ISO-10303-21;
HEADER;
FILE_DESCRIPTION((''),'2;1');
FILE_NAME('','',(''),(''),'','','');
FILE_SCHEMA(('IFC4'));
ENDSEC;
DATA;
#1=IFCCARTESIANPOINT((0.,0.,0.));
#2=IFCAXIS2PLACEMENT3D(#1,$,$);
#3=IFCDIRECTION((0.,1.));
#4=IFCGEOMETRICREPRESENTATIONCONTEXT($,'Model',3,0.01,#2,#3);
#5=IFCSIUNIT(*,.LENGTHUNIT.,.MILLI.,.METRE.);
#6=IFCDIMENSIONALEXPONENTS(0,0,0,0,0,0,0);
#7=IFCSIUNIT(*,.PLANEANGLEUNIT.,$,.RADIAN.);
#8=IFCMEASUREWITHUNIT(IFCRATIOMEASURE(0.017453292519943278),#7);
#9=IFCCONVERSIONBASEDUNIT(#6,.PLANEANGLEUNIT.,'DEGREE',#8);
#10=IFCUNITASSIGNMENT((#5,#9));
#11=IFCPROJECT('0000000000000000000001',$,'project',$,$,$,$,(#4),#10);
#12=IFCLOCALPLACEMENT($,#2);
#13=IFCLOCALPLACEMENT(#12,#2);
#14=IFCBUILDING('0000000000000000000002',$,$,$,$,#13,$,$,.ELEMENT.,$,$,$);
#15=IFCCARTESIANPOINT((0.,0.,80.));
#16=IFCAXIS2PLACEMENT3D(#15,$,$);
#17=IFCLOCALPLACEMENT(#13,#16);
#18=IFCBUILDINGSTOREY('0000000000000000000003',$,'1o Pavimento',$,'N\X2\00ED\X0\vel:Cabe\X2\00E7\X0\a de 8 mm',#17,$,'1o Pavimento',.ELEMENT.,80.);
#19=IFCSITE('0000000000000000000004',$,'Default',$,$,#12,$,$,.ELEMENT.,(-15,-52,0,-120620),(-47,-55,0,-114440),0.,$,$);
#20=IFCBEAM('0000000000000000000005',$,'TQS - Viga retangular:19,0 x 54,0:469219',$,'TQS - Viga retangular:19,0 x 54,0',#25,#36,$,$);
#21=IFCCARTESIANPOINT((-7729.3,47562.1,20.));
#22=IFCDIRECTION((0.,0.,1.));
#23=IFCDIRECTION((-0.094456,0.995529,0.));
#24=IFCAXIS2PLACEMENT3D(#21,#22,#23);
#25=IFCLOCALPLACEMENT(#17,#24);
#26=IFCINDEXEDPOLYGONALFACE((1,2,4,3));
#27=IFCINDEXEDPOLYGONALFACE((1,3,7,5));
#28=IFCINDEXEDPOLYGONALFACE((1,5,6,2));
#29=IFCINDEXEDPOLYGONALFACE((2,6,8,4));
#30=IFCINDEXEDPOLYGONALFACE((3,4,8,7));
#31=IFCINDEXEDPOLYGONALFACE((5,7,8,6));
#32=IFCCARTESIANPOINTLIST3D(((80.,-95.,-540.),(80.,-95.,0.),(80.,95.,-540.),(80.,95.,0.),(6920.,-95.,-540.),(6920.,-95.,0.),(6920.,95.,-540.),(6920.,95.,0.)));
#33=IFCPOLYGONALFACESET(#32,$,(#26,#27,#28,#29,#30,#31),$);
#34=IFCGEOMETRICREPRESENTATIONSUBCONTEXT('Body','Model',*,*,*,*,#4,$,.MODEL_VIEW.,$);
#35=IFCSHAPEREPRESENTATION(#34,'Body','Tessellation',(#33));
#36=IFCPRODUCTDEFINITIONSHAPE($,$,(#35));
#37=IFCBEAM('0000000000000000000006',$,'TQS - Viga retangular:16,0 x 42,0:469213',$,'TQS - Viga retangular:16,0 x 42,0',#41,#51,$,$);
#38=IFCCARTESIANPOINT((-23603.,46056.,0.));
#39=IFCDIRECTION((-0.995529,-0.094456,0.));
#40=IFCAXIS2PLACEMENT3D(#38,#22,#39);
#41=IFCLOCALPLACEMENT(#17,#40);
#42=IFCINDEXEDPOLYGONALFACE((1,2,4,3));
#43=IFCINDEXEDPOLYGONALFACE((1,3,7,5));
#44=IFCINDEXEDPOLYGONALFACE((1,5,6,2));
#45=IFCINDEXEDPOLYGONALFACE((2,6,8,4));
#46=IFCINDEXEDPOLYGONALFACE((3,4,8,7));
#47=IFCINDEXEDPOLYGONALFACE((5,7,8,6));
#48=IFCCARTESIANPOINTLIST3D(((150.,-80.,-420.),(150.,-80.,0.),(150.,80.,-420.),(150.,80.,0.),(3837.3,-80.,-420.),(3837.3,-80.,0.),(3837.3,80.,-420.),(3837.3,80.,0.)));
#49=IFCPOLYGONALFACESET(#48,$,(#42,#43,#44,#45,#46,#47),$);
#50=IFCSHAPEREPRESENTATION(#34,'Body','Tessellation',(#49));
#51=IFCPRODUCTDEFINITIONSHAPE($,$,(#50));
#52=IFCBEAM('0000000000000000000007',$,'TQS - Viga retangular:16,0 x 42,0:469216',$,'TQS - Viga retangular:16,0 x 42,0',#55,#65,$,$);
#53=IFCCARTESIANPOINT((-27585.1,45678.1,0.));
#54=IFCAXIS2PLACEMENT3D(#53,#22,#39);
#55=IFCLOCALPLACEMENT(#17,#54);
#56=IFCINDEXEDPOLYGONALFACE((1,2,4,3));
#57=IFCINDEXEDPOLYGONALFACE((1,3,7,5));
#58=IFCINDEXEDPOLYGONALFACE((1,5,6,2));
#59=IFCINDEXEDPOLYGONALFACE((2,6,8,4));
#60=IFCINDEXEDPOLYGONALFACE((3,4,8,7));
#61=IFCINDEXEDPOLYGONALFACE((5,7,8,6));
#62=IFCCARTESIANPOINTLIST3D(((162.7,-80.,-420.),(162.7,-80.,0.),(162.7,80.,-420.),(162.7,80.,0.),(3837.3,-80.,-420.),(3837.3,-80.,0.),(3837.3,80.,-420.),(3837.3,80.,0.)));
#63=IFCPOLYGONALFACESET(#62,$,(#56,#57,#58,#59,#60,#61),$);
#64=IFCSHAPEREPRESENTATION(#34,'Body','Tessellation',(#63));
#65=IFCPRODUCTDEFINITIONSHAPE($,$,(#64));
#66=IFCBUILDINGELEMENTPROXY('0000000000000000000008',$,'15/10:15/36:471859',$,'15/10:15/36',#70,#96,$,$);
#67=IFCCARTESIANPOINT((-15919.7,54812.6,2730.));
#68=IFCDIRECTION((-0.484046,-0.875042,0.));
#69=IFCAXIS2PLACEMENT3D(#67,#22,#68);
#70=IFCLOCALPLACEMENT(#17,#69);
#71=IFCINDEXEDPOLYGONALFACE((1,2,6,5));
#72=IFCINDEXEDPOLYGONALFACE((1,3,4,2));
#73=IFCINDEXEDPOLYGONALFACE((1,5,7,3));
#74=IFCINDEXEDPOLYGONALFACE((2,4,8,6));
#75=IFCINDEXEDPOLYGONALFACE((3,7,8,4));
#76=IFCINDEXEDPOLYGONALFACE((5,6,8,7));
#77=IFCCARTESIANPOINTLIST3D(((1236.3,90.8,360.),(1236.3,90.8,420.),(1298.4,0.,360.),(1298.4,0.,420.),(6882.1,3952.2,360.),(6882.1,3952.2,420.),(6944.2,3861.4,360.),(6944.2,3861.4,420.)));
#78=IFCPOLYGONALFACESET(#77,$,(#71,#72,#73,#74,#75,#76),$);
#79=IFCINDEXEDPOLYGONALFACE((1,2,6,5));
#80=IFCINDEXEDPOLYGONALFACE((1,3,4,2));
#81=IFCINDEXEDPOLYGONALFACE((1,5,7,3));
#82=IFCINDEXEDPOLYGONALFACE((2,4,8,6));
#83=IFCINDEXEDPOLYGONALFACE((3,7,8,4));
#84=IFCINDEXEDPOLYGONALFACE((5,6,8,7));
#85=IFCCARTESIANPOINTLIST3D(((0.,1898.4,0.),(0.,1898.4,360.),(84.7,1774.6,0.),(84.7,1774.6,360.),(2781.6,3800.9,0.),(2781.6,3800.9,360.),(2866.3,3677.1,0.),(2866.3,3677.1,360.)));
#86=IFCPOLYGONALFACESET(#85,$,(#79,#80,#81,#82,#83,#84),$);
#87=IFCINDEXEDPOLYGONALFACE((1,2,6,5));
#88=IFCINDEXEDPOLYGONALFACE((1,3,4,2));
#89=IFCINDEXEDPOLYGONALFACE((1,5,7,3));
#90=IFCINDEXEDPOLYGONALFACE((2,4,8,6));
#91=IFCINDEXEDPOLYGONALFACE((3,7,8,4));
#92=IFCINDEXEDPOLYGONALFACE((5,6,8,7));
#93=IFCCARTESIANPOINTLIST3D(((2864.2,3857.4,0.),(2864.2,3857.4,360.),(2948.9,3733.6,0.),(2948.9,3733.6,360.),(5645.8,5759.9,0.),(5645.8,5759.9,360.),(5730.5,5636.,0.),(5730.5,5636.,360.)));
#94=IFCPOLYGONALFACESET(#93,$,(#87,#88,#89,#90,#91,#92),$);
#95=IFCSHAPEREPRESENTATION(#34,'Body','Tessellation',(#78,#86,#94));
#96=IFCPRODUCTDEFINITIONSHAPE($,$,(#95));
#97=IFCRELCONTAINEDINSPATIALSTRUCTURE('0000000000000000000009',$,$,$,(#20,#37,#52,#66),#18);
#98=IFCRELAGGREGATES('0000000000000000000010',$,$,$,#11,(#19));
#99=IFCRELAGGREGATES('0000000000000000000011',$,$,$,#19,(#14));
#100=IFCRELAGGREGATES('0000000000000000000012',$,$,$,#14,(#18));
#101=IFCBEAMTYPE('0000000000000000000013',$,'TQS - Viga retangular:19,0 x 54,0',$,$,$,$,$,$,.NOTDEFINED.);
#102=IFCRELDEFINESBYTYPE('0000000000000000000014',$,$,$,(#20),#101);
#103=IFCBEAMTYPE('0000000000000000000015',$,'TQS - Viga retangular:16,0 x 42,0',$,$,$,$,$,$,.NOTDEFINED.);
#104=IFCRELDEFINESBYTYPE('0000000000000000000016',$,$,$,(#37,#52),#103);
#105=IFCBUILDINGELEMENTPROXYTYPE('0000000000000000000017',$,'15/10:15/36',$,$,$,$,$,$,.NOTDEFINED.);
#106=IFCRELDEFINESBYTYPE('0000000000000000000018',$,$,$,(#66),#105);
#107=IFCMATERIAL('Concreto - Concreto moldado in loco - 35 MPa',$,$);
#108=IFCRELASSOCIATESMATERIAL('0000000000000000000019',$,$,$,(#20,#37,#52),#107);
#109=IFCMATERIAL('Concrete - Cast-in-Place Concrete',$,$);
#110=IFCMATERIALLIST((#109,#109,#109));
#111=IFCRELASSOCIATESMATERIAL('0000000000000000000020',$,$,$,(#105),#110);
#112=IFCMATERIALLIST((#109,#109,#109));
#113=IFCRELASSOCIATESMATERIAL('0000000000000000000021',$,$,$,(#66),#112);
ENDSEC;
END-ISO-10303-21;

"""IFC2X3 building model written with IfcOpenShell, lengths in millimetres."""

from ifc_helpers import new_model, entity, si_unit, converted_unit, direction, frame, frame_2d, origin, place, context, subcontext, project, spatial, rectangle, extrude, source, transform, mapped, material, material_list, type_object, type_shapes, element, save


model = new_model("IFC2X3")

# Units and contexts
model_context = context("Model", 3, precision=0.01, world=origin(), true_north=direction((0.0, 1.0)))
body_context = subcontext(model_context, "Body", "Model", "MODEL_VIEW")
ifc_project = project(units=[si_unit("LENGTHUNIT", "METRE", prefix="MILLI"), converted_unit("PLANEANGLEUNIT", "DEGREE", entity("IfcRatioMeasure", 0.017453292519943278), si_unit("PLANEANGLEUNIT", "RADIAN"), dimensions=[0, 0, 0, 0, 0, 0, 0])], contexts=[model_context])

# Site, building, storey
site_placement = place(None, origin())
site = spatial("IfcSite", under=ifc_project, at=site_placement, Name="Default", CompositionType="ELEMENT", RefLatitude=(-15, -52, 0, -120620), RefLongitude=(-47, -55, 0, -114440), RefElevation=0.0)
building_placement = place(site_placement, origin())
building = spatial("IfcBuilding", under=site, at=building_placement, CompositionType="ELEMENT")
storey_placement = place(building_placement, frame((0.0, 0.0, 80.0)))
storey = spatial("IfcBuildingStorey", under=building, at=storey_placement, Name="1o Pavimento", ObjectType="Nível:Cabeça de 8 mm", LongName="1o Pavimento", CompositionType="ELEMENT", Elevation=80.0)

# Beams
ifc_material_1 = material(Name="Concreto - Concreto moldado in loco - 35 MPa")
beam_type_1 = type_object("IfcBeamType", Name="TQS - Viga retangular:19,0 x 54,0", PredefinedType="NOTDEFINED")
beam_1_placement = place(storey_placement, frame((-7729.3, 47562.1, 20.0), z_axis=(0.0, 0.0, 1.0), x_axis=(-0.094456, 0.995529, 0.0)))
element("IfcBeam", 1, at=beam_1_placement, inside=storey, type_object=beam_type_1, material=ifc_material_1, Name="TQS - Viga retangular:19,0 x 54,0:469219", ObjectType="TQS - Viga retangular:19,0 x 54,0", context=body_context, shape_type="SweptSolid", body=[
    extrude(rectangle(XDim=540.0, YDim=190.0, at=frame_2d((0.0, 0.0), x_axis=(1.0, 0.0))), frame((80.0, 0.0, -270.0), z_axis=(1.0, 0.0, 0.0), x_axis=(0.0, 0.0, -1.0)), (0.0, 0.0, 1.0), 6840.0),
])
beam_type_2 = type_object("IfcBeamType", Name="TQS - Viga retangular:16,0 x 42,0", PredefinedType="NOTDEFINED")
beam_2_placement = place(storey_placement, frame((-23603.0, 46056.0, 0.0), z_axis=(0.0, 0.0, 1.0), x_axis=(-0.995529, -0.094456, 0.0)))
element("IfcBeam", 2, at=beam_2_placement, inside=storey, type_object=beam_type_2, material=ifc_material_1, Name="TQS - Viga retangular:16,0 x 42,0:469213", ObjectType="TQS - Viga retangular:16,0 x 42,0", context=body_context, shape_type="SweptSolid", body=[
    extrude(rectangle(XDim=420.0, YDim=160.0, at=frame_2d((0.0, 0.0), x_axis=(1.0, 0.0))), frame((150.0, 0.0, -210.0), z_axis=(1.0, 0.0, 0.0), x_axis=(0.0, 0.0, -1.0)), (0.0, 0.0, 1.0), 3687.3),
])
beam_3_placement = place(storey_placement, frame((-27585.1, 45678.1, 0.0), z_axis=(0.0, 0.0, 1.0), x_axis=(-0.995529, -0.094456, 0.0)))
element("IfcBeam", 3, at=beam_3_placement, inside=storey, type_object=beam_type_2, material=ifc_material_1, Name="TQS - Viga retangular:16,0 x 42,0:469216", ObjectType="TQS - Viga retangular:16,0 x 42,0", context=body_context, shape_type="SweptSolid", body=[
    extrude(rectangle(XDim=420.0, YDim=160.0, at=frame_2d((0.0, 0.0), x_axis=(1.0, 0.0))), frame((162.7, 0.0, -210.0), z_axis=(1.0, 0.0, 0.0), x_axis=(0.0, 0.0, -1.0)), (0.0, 0.0, 1.0), 3674.6),
])

# Building element proxy
ifc_material_2 = material(Name="Concrete - Cast-in-Place Concrete")
ifc_material_list_1 = material_list([ifc_material_2, ifc_material_2, ifc_material_2])
ifc_material_list_2 = material_list([ifc_material_2, ifc_material_2, ifc_material_2])
building_element_proxy_type_1 = type_object("IfcBuildingElementProxyType", Name="15/10:15/36", PredefinedType="NOTDEFINED", material=ifc_material_list_2)
shared_shape_1 = source(origin(), body_context, "Body", "SweptSolid", [
    extrude(rectangle(XDim=110.0, YDim=6840.0, at=frame_2d((0.0, 0.0), x_axis=(1.0, 0.0))), frame((4090.3, 1976.1, 360.0), z_axis=(0.0, 0.0, 1.0), x_axis=(-0.564535, 0.825409, 0.0)), (0.0, 0.0, 1.0), 60.0),
    extrude(rectangle(XDim=3370.0, YDim=150.0, at=frame_2d((0.0, 0.0), x_axis=(1.0, 0.0))), frame((1433.2, 2787.8, 0.0), z_axis=(0.0, 0.0, 1.0), x_axis=(0.825409, 0.564535, 0.0)), (0.0, 0.0, 1.0), 360.0),
    extrude(rectangle(XDim=3370.0, YDim=150.0, at=frame_2d((0.0, 0.0), x_axis=(1.0, 0.0))), frame((4297.3, 4746.7, 0.0), z_axis=(0.0, 0.0, 1.0), x_axis=(0.825409, 0.564535, 0.0)), (0.0, 0.0, 1.0), 360.0),
])
type_shapes(building_element_proxy_type_1, [shared_shape_1])
proxy_1_placement = place(storey_placement, frame((-15919.7, 54812.6, 2730.0), z_axis=(0.0, 0.0, 1.0), x_axis=(-0.484046, -0.875042, 0.0)))
element("IfcBuildingElementProxy", 4, at=proxy_1_placement, inside=storey, type_object=building_element_proxy_type_1, material=ifc_material_list_1, Name="15/10:15/36:471859", ObjectType="15/10:15/36", context=body_context, shape_type="MappedRepresentation", body=[
    mapped(shared_shape_1, transform((0.0, 0.0, 0.0), scale=1.0)),
])

save(model, "model.ifc")
